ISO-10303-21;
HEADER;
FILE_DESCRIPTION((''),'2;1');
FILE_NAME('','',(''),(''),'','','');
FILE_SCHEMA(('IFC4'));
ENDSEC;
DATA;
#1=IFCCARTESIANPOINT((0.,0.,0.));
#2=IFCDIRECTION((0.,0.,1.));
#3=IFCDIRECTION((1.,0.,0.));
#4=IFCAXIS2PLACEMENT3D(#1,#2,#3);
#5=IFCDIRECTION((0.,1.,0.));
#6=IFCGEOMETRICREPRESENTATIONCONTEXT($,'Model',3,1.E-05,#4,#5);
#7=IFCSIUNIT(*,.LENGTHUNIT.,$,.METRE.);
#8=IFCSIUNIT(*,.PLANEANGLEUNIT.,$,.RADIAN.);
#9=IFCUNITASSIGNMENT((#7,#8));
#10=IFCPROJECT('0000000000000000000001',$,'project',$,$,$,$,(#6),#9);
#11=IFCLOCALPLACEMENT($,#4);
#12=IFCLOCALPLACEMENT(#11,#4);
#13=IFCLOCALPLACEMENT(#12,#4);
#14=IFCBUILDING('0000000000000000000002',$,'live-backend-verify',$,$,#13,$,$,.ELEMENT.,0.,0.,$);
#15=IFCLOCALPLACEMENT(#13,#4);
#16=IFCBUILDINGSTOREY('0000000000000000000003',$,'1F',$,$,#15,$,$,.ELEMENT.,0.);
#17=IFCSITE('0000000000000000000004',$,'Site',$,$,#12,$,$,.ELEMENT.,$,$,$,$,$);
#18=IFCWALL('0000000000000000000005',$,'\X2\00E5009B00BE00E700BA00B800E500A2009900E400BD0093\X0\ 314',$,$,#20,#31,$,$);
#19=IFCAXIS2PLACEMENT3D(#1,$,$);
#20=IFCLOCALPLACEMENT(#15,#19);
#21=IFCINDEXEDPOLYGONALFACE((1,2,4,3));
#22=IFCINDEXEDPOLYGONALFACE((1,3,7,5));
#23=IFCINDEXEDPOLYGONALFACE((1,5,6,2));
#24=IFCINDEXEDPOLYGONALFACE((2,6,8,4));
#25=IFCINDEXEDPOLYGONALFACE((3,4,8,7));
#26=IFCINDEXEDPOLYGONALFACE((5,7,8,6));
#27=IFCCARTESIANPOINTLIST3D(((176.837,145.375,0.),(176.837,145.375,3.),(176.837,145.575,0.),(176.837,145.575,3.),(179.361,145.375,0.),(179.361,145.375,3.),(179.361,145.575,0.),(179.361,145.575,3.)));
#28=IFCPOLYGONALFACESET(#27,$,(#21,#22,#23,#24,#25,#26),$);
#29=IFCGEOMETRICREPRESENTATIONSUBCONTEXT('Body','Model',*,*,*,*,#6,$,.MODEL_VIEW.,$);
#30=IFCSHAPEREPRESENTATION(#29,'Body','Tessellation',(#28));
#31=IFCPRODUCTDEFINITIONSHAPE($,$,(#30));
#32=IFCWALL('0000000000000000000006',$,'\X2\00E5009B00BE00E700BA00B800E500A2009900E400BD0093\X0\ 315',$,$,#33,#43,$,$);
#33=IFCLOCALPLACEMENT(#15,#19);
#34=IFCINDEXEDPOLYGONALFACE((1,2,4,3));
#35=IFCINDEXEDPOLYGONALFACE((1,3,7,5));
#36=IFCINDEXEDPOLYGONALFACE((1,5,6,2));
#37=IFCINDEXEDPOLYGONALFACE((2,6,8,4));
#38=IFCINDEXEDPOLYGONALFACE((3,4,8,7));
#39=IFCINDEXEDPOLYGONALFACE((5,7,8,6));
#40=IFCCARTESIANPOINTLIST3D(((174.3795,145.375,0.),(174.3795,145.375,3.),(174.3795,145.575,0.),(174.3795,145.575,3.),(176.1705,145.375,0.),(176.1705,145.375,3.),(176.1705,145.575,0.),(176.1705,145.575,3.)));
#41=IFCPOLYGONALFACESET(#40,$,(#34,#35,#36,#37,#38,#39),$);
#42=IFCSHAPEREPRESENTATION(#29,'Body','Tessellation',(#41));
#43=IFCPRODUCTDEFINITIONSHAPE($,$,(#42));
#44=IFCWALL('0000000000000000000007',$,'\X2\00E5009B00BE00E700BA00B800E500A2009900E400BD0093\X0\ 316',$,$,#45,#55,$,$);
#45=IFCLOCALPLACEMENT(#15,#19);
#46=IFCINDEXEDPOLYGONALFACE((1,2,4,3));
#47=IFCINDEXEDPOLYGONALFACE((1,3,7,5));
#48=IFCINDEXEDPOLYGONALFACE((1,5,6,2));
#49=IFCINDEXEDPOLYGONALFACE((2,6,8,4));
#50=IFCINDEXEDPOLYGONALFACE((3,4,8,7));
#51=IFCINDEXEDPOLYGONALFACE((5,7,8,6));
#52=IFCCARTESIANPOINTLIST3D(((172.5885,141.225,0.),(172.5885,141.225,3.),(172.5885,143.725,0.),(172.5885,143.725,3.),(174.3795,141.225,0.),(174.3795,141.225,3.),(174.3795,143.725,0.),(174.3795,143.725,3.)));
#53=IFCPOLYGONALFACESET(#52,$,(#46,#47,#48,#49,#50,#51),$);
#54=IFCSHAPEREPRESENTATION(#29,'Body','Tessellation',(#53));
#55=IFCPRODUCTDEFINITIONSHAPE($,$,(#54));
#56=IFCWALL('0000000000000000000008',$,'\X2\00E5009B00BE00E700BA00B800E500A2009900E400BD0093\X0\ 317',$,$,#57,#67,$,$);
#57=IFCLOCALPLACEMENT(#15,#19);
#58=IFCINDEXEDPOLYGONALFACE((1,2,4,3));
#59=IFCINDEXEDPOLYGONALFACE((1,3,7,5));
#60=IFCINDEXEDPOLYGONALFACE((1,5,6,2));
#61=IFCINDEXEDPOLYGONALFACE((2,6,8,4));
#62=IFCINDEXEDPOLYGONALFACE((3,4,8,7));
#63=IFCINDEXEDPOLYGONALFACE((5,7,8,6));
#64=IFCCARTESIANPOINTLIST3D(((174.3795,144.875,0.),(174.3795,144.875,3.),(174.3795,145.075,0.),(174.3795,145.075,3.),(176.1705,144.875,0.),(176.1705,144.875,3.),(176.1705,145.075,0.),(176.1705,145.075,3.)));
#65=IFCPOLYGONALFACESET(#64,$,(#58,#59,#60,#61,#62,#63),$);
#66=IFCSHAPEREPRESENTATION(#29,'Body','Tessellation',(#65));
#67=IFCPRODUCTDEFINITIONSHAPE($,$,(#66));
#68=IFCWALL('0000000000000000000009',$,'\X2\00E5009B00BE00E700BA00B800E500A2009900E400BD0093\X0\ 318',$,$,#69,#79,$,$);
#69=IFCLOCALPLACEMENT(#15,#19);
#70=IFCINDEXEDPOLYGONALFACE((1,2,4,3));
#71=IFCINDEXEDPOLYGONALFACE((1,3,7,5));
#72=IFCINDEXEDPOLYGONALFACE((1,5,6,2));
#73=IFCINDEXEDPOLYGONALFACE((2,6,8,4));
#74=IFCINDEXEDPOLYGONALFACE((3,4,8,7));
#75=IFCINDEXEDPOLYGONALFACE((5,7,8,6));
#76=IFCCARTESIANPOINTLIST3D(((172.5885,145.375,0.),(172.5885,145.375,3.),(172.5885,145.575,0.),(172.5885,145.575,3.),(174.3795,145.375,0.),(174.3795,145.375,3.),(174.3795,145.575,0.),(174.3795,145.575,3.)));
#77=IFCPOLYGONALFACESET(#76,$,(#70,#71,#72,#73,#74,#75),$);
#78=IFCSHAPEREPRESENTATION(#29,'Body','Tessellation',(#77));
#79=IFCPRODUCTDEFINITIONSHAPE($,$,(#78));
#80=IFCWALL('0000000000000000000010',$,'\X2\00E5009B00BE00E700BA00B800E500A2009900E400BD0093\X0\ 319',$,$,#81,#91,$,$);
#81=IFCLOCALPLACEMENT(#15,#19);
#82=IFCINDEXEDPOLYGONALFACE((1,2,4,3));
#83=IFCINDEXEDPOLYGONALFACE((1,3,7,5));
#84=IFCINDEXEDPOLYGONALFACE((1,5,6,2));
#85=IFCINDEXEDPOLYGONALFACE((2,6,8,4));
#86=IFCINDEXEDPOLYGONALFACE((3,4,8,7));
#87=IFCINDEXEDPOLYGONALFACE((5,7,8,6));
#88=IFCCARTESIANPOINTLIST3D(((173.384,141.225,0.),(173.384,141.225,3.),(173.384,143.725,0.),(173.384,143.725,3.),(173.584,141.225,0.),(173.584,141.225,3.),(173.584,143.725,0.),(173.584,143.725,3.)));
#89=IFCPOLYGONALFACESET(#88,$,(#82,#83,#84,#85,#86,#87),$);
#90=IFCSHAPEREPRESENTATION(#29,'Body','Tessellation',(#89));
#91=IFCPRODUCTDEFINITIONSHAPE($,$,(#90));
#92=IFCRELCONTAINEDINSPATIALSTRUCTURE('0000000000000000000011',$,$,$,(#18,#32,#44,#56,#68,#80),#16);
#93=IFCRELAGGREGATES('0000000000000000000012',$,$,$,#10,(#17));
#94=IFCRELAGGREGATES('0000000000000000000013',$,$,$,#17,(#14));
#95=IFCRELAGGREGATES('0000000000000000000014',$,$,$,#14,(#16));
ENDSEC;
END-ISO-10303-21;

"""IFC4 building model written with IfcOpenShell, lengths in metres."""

from ifc_helpers import new_model, si_unit, direction, frame, frame_2d, origin_with_axes, place, context, subcontext, project, spatial, rectangle, extrude, element, save


model = new_model("IFC4")

# Units and contexts
model_context = context("Model", 3, precision=1e-05, world=origin_with_axes(), true_north=direction((0.0, 1.0, 0.0)))
body_context = subcontext(model_context, "Body", "Model", "MODEL_VIEW")
ifc_project = project(units=[si_unit("LENGTHUNIT", "METRE"), si_unit("PLANEANGLEUNIT", "RADIAN")], contexts=[model_context])

# Site, building, storey
placement = place(None, origin_with_axes())
site_placement = place(placement, origin_with_axes())
site = spatial("IfcSite", under=ifc_project, at=site_placement, Name="Site", CompositionType="ELEMENT")
building_placement = place(site_placement, origin_with_axes())
building = spatial("IfcBuilding", under=site, at=building_placement, Name="live-backend-verify", CompositionType="ELEMENT", ElevationOfRefHeight=0.0, ElevationOfTerrain=0.0)
storey_placement = place(building_placement, origin_with_axes())
storey = spatial("IfcBuildingStorey", under=building, at=storey_placement, Name="1F", CompositionType="ELEMENT", Elevation=0.0)

# Walls
for number, where, z_axis, x_axis, name in (
    (1, (178.099, 145.475, 0.0), (0.0, 0.0, 1.0), (-1.0, 0.0, 0.0), "å\u009b¾çº¸å¢\u0099ä½\u0093 314"),
):
    element("IfcWall", number, at=place(storey_placement, frame(where, z_axis=z_axis, x_axis=x_axis)), inside=storey, Name=name, context=body_context, shape_type="SweptSolid", body=[
        extrude(rectangle(XDim=2.524, YDim=0.2, at=frame_2d((0.0, 0.0), x_axis=(1.0, 0.0, 0.0))), frame((0.0, 0.0, 0.0), z_axis=(0.0, 0.0, 1.0)), (0.0, 0.0, 1.0), 3.0),
    ])
wall_1_placement = place(storey_placement, frame((175.275, 145.475, 0.0), z_axis=(0.0, 0.0, 1.0), x_axis=(-1.0, 0.0, 0.0)))
element("IfcWall", 2, at=wall_1_placement, inside=storey, Name="å\u009b¾çº¸å¢\u0099ä½\u0093 315", context=body_context, shape_type="SweptSolid", body=[
    extrude(rectangle(XDim=1.791, YDim=0.2, at=frame_2d((0.0, 0.0), x_axis=(1.0, 0.0, 0.0))), frame((0.0, 0.0, 0.0), z_axis=(0.0, 0.0, 1.0)), (0.0, 0.0, 1.0), 3.0),
])
wall_2_placement = place(storey_placement, frame((173.484, 142.475, 0.0), z_axis=(0.0, 0.0, 1.0), x_axis=(1.0, 0.0, 0.0)))
element("IfcWall", 3, at=wall_2_placement, inside=storey, Name="å\u009b¾çº¸å¢\u0099ä½\u0093 316", context=body_context, shape_type="SweptSolid", body=[
    extrude(rectangle(XDim=1.791, YDim=2.5, at=frame_2d((0.0, 0.0), x_axis=(1.0, 0.0, 0.0))), frame((0.0, 0.0, 0.0), z_axis=(0.0, 0.0, 1.0)), (0.0, 0.0, 1.0), 3.0),
])
for number, where, z_axis, x_axis, name in (
    (4, (175.275, 144.975, 0.0), (0.0, 0.0, 1.0), (-1.0, 0.0, 0.0), "å\u009b¾çº¸å¢\u0099ä½\u0093 317"),
    (5, (173.484, 145.475, 0.0), (0.0, 0.0, 1.0), (1.0, 0.0, 0.0), "å\u009b¾çº¸å¢\u0099ä½\u0093 318"),
):
    element("IfcWall", number, at=place(storey_placement, frame(where, z_axis=z_axis, x_axis=x_axis)), inside=storey, Name=name, context=body_context, shape_type="SweptSolid", body=[
        extrude(rectangle(XDim=1.791, YDim=0.2, at=frame_2d((0.0, 0.0), x_axis=(1.0, 0.0, 0.0))), frame((0.0, 0.0, 0.0), z_axis=(0.0, 0.0, 1.0)), (0.0, 0.0, 1.0), 3.0),
    ])
wall_3_placement = place(storey_placement, frame((173.484, 142.475, 0.0), z_axis=(0.0, 0.0, 1.0), x_axis=(0.0, 1.0, 0.0)))
element("IfcWall", 6, at=wall_3_placement, inside=storey, Name="å\u009b¾çº¸å¢\u0099ä½\u0093 319", context=body_context, shape_type="SweptSolid", body=[
    extrude(rectangle(XDim=2.5, YDim=0.2, at=frame_2d((0.0, 0.0), x_axis=(1.0, 0.0, 0.0))), frame((0.0, 0.0, 0.0), z_axis=(0.0, 0.0, 1.0)), (0.0, 0.0, 1.0), 3.0),
])

save(model, "model.ifc")
